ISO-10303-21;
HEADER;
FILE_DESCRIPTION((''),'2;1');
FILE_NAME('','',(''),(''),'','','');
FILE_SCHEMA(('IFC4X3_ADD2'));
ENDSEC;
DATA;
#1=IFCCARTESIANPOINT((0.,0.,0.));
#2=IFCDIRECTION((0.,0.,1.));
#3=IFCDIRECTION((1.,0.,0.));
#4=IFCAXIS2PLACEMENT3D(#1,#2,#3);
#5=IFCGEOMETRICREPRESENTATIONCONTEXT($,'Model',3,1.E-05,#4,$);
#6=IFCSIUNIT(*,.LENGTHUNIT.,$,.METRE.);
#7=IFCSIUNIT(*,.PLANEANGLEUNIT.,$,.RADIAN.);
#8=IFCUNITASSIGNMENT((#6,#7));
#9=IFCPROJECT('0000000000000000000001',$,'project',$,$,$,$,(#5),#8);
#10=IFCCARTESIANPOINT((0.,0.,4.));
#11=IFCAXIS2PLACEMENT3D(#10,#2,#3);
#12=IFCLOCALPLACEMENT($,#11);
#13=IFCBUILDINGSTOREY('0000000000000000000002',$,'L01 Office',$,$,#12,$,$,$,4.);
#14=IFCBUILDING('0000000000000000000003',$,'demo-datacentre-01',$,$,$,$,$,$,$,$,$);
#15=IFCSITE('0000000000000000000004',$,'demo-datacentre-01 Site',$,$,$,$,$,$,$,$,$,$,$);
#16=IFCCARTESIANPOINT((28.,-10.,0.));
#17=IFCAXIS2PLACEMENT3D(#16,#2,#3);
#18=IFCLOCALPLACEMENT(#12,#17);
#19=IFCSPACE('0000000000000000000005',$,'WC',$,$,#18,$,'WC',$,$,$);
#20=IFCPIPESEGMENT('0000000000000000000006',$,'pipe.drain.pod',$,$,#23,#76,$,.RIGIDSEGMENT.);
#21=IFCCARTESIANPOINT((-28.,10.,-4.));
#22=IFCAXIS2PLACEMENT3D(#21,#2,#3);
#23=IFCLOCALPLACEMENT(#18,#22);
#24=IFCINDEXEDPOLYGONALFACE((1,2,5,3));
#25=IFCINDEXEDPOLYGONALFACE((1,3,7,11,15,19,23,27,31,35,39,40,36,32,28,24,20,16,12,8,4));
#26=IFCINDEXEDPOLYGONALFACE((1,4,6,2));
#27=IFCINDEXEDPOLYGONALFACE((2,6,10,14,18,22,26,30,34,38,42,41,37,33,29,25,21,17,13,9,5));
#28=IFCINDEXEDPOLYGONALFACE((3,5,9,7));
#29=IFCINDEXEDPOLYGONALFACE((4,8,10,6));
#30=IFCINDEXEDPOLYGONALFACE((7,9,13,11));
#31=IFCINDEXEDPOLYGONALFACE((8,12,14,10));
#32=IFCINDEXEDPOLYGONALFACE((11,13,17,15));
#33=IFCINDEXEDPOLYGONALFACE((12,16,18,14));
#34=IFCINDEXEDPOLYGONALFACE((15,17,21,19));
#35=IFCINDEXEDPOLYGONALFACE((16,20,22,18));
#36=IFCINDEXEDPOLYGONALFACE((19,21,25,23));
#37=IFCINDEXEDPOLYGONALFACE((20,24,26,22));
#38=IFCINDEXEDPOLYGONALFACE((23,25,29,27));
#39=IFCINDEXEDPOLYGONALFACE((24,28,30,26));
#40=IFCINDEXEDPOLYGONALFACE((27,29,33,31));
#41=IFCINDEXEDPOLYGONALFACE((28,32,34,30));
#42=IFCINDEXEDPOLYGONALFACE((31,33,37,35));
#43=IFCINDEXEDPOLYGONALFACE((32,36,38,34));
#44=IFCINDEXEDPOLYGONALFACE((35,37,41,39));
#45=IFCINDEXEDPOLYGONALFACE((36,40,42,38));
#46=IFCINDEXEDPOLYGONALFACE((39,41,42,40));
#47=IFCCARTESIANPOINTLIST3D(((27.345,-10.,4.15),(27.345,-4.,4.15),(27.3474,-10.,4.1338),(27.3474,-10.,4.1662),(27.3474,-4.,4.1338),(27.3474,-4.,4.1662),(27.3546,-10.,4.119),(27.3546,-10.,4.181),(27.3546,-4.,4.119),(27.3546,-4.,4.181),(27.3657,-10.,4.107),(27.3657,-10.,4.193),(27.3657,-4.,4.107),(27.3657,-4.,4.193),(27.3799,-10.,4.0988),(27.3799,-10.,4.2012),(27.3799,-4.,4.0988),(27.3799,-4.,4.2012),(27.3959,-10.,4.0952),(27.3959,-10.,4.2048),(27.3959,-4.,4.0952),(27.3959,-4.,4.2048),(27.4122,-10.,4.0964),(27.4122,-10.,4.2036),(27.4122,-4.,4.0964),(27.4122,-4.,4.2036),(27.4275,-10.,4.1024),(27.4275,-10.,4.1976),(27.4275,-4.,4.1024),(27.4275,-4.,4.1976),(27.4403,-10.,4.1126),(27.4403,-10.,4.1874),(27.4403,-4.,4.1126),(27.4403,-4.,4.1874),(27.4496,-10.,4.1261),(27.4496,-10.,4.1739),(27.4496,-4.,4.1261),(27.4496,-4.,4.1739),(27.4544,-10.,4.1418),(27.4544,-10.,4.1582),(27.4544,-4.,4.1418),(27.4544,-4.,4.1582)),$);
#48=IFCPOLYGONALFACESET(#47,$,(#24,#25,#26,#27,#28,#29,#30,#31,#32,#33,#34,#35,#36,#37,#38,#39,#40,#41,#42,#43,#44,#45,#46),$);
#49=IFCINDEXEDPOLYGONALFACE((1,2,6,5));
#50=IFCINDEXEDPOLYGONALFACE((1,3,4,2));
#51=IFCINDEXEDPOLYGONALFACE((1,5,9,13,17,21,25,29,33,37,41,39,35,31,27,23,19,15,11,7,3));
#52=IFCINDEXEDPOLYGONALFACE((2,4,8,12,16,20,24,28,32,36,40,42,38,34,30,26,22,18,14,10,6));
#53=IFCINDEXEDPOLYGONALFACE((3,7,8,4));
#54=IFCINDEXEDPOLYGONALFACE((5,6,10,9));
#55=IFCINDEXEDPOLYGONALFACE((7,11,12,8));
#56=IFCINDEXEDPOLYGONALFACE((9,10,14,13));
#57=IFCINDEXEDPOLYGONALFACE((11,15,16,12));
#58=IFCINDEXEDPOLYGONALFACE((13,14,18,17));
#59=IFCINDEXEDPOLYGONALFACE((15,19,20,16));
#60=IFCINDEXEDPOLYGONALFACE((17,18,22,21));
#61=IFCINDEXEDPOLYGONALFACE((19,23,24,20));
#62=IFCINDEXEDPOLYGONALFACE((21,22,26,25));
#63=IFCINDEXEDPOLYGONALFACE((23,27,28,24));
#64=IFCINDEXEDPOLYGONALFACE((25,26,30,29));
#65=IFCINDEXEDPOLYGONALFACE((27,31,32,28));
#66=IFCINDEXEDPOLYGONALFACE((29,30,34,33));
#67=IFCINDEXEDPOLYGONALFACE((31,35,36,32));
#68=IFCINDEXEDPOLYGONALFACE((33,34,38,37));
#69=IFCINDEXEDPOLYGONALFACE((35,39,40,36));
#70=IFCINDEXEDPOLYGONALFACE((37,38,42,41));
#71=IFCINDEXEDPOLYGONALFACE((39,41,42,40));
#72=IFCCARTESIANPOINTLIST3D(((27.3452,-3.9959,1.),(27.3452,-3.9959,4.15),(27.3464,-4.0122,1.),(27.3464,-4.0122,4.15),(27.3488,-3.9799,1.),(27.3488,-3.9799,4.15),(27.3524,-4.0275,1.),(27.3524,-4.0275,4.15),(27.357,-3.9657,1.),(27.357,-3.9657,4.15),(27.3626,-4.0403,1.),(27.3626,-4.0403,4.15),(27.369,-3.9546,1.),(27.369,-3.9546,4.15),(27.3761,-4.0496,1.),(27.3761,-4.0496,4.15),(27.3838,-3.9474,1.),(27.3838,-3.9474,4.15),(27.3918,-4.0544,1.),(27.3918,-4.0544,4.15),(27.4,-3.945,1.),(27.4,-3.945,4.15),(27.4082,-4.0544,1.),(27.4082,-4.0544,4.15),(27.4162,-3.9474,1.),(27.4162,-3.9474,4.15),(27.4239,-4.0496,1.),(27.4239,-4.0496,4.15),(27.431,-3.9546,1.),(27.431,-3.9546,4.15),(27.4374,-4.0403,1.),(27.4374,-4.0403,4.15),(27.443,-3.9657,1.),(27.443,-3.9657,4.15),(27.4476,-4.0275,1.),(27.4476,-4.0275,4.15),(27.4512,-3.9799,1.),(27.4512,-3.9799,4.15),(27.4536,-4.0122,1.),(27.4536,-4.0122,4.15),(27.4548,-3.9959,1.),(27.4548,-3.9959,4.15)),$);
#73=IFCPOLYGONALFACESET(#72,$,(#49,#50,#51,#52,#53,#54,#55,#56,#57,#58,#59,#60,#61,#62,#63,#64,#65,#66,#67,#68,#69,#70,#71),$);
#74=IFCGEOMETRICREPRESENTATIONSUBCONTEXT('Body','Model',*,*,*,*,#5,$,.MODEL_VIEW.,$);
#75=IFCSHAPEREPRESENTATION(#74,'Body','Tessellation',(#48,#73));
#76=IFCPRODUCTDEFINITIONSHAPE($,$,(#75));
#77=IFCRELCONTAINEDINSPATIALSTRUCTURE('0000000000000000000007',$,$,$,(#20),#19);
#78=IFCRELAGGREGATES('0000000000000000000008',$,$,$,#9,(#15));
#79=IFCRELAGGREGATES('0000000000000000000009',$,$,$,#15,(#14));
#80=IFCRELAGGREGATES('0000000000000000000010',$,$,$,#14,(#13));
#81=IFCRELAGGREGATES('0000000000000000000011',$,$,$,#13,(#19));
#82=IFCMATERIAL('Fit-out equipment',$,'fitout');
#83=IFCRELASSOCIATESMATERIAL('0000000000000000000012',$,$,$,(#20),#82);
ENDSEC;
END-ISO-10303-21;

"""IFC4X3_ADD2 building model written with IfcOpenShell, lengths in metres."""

from ifc_helpers import new_model, si_unit, frame, origin_with_axes, place, context, subcontext, project, spatial, circle, extrude, material, element, save


model = new_model("IFC4X3_ADD2")

# Units and contexts
model_context = context("Model", 3, precision=1e-05, world=origin_with_axes())
body_context = subcontext(model_context, "Body", "Model", "MODEL_VIEW")
ifc_project = project(units=[si_unit("LENGTHUNIT", "METRE"), si_unit("PLANEANGLEUNIT", "RADIAN")], contexts=[model_context])

# Site, building, storey
site = spatial("IfcSite", under=ifc_project, Name="demo-datacentre-01 Site")
building = spatial("IfcBuilding", under=site, Name="demo-datacentre-01")
storey_placement = place(None, frame((0.0, 0.0, 4.0), z_axis=(0.0, 0.0, 1.0), x_axis=(1.0, 0.0, 0.0)))
storey = spatial("IfcBuildingStorey", under=building, at=storey_placement, Name="L01 Office", Elevation=4.0)

# Shared definitions
ifc_material_1 = material(Name="Fit-out equipment", Category="fitout")

# Shared definitions
space_1_placement = place(storey_placement, frame((28.0, -10.0, 0.0), z_axis=(0.0, 0.0, 1.0), x_axis=(1.0, 0.0, 0.0)))
space_1 = spatial("IfcSpace", under=storey, at=space_1_placement, Name="WC", LongName="WC")

# Pipe segment
pipe_segment_1_placement = place(space_1_placement, frame((-28.0, 10.0, -4.0), z_axis=(0.0, 0.0, 1.0), x_axis=(1.0, 0.0, 0.0)))
element("IfcPipeSegment", 1, at=pipe_segment_1_placement, inside=space_1, material=ifc_material_1, Name="pipe.drain.pod", PredefinedType="RIGIDSEGMENT", context=body_context, shape_type="SweptSolid", body=[
    extrude(circle(Radius=0.055), frame((27.4, -10.0, 4.15), z_axis=(0.0, 1.0, 0.0), x_axis=(-1.0, 0.0, 0.0)), (0.0, 0.0, 1.0), 6.0),
    extrude(circle(Radius=0.055), frame((27.4, -4.0, 4.15), z_axis=(0.0, 0.0, -1.0), x_axis=(0.0, 1.0, 0.0)), (0.0, 0.0, 1.0), 3.15),
])

save(model, "model.ifc")
